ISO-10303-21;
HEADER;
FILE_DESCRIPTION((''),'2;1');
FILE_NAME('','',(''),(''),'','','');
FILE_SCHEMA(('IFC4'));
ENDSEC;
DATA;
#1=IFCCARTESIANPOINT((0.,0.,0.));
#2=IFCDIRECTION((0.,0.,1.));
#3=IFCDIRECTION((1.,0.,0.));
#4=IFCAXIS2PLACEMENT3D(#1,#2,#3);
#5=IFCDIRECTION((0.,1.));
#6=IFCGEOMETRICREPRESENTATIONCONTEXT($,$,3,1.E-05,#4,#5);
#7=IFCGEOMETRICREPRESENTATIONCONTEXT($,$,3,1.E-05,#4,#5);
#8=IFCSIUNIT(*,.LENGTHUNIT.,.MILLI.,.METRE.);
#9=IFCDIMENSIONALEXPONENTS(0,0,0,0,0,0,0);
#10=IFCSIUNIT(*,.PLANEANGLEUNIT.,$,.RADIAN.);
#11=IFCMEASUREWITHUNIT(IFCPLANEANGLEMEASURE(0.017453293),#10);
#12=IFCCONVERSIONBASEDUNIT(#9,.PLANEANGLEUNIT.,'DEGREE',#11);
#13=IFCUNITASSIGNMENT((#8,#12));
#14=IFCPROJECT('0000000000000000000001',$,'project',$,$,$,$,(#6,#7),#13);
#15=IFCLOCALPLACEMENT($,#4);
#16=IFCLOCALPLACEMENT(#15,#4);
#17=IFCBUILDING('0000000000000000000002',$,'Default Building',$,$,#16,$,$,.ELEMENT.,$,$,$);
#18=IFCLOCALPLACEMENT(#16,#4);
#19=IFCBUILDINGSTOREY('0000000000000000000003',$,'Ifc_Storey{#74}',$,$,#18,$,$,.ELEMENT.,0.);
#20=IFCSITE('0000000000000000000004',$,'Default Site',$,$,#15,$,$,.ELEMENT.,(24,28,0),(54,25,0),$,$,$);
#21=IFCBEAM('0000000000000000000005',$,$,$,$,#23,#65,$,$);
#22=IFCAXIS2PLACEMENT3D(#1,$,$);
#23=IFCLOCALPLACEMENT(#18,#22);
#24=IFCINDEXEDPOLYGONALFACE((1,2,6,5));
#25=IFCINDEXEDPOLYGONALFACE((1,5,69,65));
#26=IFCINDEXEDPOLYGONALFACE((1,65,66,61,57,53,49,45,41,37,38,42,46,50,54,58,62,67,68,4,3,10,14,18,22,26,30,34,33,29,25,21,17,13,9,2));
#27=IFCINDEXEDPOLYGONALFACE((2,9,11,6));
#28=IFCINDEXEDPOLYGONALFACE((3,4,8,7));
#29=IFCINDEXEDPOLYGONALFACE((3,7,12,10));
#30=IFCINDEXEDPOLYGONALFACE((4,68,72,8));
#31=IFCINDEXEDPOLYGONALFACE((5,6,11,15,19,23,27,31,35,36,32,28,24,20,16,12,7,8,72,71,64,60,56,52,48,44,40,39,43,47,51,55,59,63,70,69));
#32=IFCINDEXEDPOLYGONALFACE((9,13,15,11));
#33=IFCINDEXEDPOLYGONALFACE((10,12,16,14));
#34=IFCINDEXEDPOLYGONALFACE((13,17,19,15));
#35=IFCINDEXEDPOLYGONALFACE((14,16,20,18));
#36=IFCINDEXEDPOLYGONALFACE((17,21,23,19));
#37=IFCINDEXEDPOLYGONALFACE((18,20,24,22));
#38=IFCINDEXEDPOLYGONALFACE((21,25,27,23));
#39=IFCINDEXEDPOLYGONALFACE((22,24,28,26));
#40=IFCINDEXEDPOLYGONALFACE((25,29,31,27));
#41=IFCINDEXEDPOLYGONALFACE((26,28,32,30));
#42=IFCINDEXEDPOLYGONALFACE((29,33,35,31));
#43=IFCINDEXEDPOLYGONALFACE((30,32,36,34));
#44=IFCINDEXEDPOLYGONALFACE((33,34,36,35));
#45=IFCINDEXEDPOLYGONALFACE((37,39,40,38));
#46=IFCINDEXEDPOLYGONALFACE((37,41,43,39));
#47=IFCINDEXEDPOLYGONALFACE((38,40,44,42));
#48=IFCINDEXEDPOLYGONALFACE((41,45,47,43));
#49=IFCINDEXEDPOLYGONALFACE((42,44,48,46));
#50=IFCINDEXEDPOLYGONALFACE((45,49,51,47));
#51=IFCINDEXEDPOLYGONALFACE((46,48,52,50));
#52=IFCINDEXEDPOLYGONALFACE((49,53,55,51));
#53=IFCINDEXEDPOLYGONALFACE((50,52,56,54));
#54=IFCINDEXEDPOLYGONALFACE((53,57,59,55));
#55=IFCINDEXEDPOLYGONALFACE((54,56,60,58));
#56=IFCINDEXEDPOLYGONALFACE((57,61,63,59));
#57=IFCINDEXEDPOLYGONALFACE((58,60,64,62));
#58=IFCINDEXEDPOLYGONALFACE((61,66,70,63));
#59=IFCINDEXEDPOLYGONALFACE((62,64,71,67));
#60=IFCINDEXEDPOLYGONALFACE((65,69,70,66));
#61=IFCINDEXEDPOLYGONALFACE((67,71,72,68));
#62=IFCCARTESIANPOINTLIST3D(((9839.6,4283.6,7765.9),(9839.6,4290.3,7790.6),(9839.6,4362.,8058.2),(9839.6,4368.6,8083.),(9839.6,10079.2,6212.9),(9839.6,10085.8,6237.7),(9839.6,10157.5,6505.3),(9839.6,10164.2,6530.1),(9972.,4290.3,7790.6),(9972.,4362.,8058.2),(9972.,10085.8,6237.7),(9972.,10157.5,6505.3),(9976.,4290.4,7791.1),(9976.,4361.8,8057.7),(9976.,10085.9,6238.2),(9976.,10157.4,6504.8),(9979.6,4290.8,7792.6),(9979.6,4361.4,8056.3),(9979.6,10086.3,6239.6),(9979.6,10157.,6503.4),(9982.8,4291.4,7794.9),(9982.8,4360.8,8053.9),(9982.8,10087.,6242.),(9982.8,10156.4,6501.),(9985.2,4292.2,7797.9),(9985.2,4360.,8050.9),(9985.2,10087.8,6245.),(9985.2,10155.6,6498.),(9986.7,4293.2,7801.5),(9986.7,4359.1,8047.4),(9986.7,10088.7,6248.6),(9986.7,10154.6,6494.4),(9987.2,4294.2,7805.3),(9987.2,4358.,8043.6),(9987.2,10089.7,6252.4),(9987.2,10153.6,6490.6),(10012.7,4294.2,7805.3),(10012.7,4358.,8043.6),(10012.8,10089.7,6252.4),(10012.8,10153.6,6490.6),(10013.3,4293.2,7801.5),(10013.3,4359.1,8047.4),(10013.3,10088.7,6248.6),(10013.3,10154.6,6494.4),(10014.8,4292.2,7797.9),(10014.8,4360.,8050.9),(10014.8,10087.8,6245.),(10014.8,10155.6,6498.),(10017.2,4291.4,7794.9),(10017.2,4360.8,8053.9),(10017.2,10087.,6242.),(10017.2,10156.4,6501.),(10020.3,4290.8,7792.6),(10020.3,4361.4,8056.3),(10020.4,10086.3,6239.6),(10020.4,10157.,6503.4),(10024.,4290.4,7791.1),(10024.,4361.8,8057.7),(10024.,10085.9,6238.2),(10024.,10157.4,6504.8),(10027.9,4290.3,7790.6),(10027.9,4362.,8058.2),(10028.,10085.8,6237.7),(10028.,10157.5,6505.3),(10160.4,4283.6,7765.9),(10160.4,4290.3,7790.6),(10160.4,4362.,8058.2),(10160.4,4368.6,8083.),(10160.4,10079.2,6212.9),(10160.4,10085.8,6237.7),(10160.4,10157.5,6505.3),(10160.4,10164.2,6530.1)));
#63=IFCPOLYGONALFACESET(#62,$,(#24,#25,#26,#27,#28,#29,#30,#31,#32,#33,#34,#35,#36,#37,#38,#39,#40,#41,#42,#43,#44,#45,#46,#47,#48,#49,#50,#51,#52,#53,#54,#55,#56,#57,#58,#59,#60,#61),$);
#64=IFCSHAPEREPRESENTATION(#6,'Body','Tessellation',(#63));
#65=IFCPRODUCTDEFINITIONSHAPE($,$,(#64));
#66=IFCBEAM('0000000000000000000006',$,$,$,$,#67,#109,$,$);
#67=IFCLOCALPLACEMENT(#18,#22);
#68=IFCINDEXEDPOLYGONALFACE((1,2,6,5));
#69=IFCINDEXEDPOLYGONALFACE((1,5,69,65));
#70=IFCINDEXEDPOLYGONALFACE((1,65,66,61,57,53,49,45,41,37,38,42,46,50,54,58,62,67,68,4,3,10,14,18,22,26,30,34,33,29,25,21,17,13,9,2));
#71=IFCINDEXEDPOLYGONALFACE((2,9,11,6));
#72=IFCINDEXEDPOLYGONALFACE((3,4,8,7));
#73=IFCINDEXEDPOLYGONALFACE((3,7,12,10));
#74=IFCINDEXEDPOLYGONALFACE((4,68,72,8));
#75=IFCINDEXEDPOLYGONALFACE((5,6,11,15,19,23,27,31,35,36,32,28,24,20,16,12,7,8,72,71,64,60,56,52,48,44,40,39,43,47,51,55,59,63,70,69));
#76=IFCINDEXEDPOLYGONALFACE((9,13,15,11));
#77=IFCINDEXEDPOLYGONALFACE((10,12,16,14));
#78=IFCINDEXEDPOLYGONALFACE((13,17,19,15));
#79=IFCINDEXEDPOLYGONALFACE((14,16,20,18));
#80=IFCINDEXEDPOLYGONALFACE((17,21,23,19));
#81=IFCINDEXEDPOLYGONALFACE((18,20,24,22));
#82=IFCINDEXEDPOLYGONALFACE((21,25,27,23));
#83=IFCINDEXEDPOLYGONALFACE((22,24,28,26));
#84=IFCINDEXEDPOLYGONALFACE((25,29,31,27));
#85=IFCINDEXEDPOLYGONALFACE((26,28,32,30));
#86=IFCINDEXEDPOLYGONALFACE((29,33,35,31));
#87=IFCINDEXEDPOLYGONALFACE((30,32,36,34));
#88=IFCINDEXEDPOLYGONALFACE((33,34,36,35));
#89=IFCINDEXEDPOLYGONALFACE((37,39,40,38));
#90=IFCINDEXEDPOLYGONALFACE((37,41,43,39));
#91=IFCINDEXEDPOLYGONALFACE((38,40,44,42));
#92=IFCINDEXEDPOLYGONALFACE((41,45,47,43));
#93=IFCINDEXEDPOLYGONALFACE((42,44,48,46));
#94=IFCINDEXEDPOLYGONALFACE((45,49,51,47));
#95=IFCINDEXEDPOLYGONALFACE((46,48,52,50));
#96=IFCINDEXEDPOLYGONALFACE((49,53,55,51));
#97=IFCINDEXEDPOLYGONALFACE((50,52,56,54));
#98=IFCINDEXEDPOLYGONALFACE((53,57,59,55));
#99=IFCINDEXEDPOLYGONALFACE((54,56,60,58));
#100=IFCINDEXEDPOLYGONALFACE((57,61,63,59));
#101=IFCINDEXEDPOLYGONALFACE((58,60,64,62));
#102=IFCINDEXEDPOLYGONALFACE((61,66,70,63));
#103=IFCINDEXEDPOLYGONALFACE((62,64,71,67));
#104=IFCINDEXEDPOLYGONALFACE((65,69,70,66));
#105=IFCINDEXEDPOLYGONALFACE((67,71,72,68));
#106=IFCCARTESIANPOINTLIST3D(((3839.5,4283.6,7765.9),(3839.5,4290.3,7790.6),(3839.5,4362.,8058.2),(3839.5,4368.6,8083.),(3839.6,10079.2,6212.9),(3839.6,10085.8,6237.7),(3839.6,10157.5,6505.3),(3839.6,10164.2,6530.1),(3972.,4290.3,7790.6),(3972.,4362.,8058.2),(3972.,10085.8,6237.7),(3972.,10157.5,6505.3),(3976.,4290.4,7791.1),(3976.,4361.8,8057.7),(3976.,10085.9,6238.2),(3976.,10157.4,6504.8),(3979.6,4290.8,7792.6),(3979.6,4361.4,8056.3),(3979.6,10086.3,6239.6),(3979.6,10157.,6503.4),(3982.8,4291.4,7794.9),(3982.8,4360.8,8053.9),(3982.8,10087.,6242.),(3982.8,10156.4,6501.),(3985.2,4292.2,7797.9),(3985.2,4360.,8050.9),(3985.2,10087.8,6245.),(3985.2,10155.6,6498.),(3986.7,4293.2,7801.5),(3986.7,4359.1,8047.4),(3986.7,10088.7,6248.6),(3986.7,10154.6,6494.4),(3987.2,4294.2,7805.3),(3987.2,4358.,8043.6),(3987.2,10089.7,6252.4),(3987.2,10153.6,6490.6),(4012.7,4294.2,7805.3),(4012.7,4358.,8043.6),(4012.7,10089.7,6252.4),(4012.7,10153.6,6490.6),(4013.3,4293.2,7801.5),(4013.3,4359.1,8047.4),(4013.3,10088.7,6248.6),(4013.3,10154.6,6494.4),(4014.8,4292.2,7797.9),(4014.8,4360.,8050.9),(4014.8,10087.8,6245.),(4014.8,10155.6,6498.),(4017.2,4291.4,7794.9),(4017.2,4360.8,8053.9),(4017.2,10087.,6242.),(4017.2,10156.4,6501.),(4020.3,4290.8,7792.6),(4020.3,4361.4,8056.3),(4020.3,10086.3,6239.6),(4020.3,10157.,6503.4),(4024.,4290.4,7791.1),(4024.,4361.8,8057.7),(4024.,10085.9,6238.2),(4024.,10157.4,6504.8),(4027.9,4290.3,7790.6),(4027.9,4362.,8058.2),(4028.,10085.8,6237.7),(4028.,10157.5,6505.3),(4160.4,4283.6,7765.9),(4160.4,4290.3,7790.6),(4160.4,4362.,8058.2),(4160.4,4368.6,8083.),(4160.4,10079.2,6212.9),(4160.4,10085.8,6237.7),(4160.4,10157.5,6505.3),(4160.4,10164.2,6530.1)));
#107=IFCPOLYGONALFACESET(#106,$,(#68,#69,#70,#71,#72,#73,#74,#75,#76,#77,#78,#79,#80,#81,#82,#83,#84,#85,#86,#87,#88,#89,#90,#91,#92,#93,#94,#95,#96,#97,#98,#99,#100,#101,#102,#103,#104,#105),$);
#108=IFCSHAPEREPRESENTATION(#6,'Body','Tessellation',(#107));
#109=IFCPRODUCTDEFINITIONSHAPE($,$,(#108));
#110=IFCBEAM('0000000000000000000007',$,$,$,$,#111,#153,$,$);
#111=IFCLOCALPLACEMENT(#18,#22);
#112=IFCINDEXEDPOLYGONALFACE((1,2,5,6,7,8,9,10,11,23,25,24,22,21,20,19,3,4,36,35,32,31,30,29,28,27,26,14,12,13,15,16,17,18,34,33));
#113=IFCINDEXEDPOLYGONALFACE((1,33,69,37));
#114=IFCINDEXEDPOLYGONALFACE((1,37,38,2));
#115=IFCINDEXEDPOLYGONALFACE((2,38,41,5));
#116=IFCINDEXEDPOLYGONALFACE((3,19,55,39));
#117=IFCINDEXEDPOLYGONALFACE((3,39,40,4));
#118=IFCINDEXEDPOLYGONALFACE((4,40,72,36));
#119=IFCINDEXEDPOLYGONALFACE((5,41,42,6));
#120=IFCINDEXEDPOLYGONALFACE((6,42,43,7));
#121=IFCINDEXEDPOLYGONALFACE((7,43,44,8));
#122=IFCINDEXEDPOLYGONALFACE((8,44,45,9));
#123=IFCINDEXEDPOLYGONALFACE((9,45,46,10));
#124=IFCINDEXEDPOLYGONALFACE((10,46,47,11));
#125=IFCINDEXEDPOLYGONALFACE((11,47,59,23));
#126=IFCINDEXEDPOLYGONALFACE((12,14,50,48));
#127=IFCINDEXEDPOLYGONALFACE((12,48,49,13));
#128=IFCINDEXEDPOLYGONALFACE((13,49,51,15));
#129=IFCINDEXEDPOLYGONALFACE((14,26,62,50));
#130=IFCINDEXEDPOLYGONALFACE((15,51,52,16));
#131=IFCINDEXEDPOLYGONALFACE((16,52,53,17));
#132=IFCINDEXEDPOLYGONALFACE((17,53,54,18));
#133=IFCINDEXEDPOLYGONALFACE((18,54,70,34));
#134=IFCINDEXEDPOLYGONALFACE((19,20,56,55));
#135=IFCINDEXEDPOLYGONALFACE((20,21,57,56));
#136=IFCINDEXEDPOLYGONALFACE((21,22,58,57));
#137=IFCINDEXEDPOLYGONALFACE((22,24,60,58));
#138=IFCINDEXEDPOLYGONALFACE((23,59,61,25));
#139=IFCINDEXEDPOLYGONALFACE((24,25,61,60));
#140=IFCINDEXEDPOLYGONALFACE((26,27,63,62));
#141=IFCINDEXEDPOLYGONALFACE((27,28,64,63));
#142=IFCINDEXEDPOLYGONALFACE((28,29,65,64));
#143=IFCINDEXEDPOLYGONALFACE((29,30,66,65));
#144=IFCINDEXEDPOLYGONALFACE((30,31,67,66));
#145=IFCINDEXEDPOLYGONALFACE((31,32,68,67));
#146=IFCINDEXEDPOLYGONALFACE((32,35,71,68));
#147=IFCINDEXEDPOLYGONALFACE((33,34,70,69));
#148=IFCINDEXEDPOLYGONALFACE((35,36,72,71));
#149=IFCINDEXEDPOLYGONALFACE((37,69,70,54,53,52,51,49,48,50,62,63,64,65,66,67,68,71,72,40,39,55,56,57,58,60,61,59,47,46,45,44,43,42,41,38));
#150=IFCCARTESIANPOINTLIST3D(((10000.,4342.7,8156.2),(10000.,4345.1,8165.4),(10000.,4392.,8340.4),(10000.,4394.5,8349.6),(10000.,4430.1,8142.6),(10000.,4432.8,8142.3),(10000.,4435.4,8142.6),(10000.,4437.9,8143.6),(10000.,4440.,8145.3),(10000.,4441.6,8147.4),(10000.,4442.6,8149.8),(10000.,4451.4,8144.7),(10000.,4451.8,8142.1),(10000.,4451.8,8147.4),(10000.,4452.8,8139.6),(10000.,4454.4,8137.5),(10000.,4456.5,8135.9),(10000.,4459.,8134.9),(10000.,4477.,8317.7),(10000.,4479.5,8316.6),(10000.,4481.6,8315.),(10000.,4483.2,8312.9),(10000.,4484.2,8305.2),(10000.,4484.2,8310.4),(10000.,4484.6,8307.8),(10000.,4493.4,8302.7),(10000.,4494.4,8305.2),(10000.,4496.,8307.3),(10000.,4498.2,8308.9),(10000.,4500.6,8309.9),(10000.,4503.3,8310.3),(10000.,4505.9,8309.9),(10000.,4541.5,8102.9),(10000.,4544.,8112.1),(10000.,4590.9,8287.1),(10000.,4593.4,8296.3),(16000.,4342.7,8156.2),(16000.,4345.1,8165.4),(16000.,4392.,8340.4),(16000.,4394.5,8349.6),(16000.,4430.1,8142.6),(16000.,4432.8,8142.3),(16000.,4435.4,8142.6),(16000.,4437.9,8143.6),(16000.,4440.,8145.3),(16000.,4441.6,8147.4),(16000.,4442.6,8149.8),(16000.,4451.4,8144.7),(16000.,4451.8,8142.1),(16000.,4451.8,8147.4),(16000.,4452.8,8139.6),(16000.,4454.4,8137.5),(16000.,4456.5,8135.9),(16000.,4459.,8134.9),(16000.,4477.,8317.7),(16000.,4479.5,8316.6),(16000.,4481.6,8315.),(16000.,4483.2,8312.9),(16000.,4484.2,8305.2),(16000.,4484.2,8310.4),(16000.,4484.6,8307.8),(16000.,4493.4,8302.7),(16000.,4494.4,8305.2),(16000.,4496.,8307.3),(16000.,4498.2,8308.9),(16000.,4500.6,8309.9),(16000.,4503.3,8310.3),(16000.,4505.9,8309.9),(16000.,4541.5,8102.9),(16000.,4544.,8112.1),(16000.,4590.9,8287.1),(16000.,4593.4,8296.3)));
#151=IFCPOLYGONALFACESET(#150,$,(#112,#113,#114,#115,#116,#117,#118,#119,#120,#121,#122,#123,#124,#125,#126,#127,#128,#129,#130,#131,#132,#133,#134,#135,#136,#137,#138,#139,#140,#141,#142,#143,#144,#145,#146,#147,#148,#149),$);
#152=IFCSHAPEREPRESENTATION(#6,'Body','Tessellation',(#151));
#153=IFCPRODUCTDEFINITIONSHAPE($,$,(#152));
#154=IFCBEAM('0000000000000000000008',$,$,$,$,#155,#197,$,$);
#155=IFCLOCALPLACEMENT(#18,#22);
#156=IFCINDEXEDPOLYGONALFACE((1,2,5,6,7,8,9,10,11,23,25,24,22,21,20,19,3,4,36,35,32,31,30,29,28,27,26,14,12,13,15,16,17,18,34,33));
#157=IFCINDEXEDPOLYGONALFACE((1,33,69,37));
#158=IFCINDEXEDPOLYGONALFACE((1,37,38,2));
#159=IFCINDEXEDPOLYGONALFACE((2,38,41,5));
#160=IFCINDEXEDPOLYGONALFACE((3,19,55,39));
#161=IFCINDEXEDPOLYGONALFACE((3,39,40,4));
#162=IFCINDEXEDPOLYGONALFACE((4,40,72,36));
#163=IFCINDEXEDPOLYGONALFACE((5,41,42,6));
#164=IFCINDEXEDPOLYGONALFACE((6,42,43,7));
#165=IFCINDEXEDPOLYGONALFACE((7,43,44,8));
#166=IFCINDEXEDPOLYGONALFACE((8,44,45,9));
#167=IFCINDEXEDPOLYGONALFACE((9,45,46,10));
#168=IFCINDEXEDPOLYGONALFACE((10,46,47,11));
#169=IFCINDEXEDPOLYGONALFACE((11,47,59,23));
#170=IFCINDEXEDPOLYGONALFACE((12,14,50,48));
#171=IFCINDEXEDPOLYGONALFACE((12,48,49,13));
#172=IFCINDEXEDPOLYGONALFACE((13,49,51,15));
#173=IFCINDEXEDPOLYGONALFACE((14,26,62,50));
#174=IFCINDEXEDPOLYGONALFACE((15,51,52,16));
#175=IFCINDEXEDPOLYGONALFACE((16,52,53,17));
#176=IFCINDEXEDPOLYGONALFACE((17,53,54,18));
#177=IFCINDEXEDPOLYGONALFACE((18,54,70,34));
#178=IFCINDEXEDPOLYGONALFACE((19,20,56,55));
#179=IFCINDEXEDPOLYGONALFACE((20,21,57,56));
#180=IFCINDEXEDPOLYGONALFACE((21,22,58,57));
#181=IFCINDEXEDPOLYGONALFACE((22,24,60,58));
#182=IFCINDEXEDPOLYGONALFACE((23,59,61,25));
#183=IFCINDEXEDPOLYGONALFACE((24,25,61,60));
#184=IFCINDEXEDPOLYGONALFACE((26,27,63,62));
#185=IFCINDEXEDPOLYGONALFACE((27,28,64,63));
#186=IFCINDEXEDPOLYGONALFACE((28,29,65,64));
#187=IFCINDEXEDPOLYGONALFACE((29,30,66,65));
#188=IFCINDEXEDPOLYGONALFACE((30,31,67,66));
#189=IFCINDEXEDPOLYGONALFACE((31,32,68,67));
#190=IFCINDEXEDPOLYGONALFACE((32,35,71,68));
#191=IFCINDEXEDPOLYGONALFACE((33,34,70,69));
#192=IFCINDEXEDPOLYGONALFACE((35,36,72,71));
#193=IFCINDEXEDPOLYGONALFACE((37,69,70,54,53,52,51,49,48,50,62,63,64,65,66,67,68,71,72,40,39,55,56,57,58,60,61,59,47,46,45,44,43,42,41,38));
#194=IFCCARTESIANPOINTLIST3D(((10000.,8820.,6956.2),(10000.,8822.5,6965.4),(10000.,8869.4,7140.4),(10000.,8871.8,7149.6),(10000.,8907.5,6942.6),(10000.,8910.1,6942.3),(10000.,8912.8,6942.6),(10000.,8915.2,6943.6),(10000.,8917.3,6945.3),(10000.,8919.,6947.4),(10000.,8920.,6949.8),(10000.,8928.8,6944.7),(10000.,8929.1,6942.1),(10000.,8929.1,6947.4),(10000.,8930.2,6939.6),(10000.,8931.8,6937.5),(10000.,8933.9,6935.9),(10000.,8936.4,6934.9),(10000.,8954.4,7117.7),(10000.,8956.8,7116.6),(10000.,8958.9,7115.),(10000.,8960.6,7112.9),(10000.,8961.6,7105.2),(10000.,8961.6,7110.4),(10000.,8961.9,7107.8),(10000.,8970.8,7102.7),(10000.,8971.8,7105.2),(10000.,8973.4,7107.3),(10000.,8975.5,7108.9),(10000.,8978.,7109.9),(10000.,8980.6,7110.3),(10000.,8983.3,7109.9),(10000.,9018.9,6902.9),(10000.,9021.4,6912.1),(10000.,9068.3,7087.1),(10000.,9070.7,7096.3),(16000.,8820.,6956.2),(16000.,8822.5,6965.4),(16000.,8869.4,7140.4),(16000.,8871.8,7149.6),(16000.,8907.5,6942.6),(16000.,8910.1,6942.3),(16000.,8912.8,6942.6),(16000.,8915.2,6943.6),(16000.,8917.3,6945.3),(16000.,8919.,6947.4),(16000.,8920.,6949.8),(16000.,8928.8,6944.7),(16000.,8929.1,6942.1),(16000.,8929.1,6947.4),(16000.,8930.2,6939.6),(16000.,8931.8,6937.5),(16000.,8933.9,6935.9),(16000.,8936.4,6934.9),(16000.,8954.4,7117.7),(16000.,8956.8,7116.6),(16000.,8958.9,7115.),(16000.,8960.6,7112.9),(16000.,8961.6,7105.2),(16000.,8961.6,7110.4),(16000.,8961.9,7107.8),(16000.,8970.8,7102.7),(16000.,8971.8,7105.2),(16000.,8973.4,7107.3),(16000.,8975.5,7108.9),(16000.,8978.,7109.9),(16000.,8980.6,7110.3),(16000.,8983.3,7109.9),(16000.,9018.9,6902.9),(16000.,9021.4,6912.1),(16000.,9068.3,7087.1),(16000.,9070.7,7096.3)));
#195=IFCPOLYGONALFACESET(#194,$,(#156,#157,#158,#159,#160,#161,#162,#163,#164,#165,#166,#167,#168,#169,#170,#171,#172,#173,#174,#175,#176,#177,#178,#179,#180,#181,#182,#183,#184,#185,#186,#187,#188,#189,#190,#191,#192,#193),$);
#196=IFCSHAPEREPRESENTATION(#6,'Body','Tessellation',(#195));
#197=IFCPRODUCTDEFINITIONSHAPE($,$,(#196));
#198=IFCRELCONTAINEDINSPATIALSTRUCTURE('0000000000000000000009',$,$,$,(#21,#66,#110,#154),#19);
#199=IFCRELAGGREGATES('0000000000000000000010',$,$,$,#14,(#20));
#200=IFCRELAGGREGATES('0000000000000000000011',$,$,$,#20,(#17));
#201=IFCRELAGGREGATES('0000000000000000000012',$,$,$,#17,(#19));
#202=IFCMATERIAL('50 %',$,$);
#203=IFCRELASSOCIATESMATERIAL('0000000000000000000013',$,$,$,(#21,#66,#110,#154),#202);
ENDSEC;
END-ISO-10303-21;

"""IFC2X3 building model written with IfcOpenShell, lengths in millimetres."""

from ifc_helpers import new_model, entity, si_unit, converted_unit, direction, frame, origin_with_axes, origin_2d_with_axis, place, context, project, spatial, i_section, extrude, material, element, save


model = new_model("IFC2X3")

# Units and contexts
context_of_model_1 = context(None, 3, precision=1e-05, world=origin_with_axes(), true_north=direction((0.0, 1.0)))
context_of_model_2 = context(None, 3, precision=1e-05, world=origin_with_axes(), true_north=direction((0.0, 1.0)))
ifc_project = project(units=[si_unit("LENGTHUNIT", "METRE", prefix="MILLI"), converted_unit("PLANEANGLEUNIT", "DEGREE", entity("IfcPlaneAngleMeasure", 0.017453293), si_unit("PLANEANGLEUNIT", "RADIAN"), dimensions=[0, 0, 0, 0, 0, 0, 0])], contexts=[context_of_model_1, context_of_model_2])

# Site, building, storey
site_placement = place(None, origin_with_axes())
site = spatial("IfcSite", under=ifc_project, at=site_placement, Name="Default Site", CompositionType="ELEMENT", RefLatitude=(24, 28, 0), RefLongitude=(54, 25, 0))
building_placement = place(site_placement, origin_with_axes())
building = spatial("IfcBuilding", under=site, at=building_placement, Name="Default Building", CompositionType="ELEMENT")
storey_placement = place(building_placement, origin_with_axes())
storey = spatial("IfcBuildingStorey", under=building, at=storey_placement, Name="Ifc_Storey{#74}", CompositionType="ELEMENT", Elevation=0.0)

# Shared definitions
ifc_material_1 = material(Name="50 %")

# Beams
for number, where, z_axis, x_axis in (
    (1, (10000.0, 10121.7, 6371.5), (0.0, 0.0, 1.0), (0.0, -1.0, 0.0)),
    (2, (4000.0, 10121.7, 6371.5), (0.0, 0.0, 1.0), (0.0, -1.0, 0.0)),
):
    element("IfcBeam", number, at=place(storey_placement, frame(where, z_axis=z_axis, x_axis=x_axis)), inside=storey, material=ifc_material_1, context=context_of_model_1, shape_type="SweptSolid", body=[
        extrude(i_section(OverallWidth=320.9, OverallDepth=328.3, WebThickness=25.5, FlangeThickness=25.6, FilletRadius=15.2, at=origin_2d_with_axis()), frame((0.0, 0.0, 0.0), z_axis=(0.965926, 0.0, 0.258819), x_axis=(0.0, 1.0, 0.0)), (0.0, 0.0, 1.0), 6000.0),
    ])
for number, where, z_axis, x_axis in (
    (3, (10000.0, 4468.0, 8226.3), (0.0, 0.258819, 0.965926), (1.0, 0.0, 0.0)),
    (4, (10000.0, 8945.4, 7026.3), (0.0, 0.258819, 0.965926), (1.0, 0.0, 0.0)),
):
    element("IfcBeam", number, at=place(storey_placement, frame(where, z_axis=z_axis, x_axis=x_axis)), inside=storey, material=ifc_material_1, context=context_of_model_1, shape_type="SweptSolid", body=[
        extrude(i_section(OverallWidth=205.9, OverallDepth=200.2, WebThickness=9.5, FlangeThickness=9.5, FilletRadius=10.2, at=origin_2d_with_axis()), frame((0.0, 0.0, 0.0), z_axis=(1.0, 0.0, 0.0), x_axis=(0.0, 1.0, 0.0)), (0.0, 0.0, 1.0), 6000.0),
    ])

save(model, "model.ifc")
